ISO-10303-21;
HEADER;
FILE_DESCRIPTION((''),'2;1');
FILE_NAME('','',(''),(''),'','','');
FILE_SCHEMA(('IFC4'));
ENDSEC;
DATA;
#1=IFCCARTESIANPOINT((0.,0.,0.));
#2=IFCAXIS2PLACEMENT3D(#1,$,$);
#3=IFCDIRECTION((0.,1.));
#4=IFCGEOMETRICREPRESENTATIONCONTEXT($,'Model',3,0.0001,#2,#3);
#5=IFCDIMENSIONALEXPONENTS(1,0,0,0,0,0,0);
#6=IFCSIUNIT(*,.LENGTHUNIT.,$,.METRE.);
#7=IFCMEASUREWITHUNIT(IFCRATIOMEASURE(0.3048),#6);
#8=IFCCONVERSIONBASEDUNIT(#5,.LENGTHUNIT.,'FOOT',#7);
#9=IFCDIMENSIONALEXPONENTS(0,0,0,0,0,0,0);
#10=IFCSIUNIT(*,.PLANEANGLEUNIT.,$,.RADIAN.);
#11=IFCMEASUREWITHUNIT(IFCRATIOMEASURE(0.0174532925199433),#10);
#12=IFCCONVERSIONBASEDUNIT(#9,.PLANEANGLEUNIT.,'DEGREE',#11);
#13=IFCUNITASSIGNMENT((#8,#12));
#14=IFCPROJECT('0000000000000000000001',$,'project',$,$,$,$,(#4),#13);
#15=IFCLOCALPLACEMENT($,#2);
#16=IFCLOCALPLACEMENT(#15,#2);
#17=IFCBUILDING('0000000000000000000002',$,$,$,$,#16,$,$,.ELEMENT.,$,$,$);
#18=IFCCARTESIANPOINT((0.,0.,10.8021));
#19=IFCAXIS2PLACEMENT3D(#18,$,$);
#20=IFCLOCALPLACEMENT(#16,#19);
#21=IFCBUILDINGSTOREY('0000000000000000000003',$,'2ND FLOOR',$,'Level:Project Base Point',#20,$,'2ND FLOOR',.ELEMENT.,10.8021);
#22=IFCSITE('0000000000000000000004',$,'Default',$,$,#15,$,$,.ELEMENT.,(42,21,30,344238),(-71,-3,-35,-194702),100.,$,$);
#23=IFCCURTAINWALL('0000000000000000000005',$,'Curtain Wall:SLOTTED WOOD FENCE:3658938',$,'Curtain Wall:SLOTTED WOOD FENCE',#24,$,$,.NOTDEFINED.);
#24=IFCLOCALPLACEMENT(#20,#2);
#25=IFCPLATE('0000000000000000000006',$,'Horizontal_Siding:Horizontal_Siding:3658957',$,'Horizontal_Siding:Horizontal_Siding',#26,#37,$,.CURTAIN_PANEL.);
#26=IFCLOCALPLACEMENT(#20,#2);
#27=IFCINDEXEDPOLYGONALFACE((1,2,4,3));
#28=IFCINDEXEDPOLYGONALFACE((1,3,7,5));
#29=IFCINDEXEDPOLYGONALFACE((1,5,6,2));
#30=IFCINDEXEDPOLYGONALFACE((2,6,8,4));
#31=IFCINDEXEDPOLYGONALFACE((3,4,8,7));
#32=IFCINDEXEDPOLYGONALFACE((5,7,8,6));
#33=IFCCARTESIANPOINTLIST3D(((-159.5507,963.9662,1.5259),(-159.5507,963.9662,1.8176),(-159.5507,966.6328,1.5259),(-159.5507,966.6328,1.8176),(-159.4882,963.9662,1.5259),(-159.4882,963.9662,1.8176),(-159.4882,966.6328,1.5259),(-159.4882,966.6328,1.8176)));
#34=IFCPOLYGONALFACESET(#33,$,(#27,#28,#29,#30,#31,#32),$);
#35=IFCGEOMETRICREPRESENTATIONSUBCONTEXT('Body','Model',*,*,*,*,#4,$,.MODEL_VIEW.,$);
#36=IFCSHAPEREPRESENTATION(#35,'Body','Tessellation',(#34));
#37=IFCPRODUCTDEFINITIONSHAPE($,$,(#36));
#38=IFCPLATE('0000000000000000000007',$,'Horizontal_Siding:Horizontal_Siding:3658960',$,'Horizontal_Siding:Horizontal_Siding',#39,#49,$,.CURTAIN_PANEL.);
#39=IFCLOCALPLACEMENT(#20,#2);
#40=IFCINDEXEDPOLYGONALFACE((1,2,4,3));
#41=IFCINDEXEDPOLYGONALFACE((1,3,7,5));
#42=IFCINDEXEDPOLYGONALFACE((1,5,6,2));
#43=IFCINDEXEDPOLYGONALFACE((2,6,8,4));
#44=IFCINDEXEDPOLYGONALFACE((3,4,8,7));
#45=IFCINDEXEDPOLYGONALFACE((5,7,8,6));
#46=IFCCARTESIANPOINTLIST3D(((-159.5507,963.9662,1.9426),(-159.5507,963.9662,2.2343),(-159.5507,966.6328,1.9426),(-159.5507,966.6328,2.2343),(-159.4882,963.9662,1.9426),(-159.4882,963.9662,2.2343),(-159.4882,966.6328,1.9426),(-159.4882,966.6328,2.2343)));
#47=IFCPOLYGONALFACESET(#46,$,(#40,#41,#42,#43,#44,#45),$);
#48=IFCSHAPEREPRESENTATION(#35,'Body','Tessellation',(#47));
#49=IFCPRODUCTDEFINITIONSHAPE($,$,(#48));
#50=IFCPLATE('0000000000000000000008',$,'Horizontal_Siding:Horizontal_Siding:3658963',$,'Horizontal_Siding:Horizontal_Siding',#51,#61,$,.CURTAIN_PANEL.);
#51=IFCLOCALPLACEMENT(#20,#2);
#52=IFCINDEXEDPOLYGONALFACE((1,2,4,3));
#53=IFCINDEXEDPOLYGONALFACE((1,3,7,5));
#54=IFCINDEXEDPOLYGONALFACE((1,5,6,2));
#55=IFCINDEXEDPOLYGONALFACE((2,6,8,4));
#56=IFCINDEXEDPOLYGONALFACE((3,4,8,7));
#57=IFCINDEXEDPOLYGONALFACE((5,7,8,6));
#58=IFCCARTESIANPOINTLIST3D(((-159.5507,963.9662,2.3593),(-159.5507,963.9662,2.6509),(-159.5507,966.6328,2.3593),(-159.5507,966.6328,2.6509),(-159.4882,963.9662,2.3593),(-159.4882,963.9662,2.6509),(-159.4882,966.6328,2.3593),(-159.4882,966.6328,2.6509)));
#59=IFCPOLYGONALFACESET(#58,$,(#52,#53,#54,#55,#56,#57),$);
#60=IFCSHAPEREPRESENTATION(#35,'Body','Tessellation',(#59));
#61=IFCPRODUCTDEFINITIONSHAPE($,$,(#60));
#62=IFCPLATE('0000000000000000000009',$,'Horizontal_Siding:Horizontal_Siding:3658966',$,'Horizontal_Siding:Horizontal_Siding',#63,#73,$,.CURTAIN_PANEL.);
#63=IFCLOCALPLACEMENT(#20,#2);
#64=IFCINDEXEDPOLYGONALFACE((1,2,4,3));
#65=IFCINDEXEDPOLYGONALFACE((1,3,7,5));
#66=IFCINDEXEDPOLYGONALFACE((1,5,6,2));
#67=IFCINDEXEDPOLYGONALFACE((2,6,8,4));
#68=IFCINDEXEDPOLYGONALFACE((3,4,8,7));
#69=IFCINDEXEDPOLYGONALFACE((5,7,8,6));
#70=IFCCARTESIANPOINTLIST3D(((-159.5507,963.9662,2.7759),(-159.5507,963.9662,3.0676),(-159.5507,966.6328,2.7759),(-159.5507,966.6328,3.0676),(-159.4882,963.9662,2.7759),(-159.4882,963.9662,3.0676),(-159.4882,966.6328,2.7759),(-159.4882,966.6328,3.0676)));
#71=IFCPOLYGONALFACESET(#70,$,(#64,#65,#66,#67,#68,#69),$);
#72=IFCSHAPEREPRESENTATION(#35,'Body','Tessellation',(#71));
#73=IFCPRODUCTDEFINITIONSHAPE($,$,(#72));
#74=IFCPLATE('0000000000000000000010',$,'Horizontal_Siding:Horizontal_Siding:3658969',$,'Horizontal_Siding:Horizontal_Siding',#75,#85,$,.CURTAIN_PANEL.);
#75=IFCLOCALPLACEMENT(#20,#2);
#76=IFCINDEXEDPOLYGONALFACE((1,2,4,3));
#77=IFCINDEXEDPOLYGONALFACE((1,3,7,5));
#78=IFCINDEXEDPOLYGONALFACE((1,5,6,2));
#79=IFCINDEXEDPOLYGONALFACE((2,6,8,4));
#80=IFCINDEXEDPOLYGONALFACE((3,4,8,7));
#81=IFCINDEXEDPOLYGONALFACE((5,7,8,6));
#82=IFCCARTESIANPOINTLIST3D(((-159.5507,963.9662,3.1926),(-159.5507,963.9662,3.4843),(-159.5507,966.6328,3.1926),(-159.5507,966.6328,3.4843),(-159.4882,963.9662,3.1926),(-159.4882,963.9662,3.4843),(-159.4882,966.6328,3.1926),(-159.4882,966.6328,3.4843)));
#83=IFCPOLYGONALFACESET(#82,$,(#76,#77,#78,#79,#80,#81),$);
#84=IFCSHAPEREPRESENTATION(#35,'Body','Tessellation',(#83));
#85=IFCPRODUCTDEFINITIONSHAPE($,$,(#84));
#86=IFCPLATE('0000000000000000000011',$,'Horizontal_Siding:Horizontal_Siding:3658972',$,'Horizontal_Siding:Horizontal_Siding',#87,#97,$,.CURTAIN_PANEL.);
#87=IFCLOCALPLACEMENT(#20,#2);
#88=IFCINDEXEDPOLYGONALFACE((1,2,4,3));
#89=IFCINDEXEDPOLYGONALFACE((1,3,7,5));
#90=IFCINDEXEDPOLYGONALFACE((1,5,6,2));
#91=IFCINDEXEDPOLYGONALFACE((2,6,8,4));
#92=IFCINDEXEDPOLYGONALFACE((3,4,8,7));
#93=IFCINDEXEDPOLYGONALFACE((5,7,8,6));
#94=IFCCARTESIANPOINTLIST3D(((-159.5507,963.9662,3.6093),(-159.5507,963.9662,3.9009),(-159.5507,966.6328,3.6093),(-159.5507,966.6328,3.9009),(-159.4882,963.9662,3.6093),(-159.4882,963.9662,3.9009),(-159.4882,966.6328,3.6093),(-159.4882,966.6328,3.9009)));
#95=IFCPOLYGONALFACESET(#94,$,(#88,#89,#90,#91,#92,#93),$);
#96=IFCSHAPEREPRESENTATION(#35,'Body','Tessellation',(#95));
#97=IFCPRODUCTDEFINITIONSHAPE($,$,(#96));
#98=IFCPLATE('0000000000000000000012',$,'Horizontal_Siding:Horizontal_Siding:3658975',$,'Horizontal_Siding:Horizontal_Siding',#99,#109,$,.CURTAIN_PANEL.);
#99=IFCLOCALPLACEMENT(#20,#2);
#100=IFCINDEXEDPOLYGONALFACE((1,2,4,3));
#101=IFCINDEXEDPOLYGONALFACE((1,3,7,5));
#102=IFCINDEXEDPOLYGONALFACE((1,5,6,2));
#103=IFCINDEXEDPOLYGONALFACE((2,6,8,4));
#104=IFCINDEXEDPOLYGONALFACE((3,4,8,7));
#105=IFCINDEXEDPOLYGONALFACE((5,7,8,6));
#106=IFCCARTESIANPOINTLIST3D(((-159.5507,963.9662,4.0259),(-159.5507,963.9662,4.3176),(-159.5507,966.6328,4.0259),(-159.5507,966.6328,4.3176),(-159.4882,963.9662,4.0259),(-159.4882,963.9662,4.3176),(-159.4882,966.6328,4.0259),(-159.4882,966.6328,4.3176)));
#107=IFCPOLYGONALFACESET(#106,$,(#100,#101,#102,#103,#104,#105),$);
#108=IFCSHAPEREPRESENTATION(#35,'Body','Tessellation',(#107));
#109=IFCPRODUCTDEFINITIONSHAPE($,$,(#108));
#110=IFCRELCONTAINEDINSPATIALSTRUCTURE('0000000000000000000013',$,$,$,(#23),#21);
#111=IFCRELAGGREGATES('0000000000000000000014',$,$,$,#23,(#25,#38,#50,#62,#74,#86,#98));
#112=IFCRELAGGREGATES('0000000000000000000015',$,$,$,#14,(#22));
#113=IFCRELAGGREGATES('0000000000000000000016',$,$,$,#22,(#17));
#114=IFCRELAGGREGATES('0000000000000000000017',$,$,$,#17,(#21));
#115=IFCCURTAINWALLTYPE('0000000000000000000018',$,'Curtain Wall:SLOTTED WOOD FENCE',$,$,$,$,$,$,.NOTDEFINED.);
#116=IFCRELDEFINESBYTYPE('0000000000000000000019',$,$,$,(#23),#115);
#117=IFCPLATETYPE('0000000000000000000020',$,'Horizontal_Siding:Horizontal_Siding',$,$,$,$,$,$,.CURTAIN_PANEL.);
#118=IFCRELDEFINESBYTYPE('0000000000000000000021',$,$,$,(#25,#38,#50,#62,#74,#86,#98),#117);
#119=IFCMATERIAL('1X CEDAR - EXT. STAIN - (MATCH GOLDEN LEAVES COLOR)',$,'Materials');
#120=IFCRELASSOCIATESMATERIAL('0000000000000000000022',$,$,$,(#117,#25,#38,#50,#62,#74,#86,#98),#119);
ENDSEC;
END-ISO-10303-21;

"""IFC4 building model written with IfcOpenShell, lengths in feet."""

from ifc_helpers import new_model, entity, si_unit, converted_unit, direction, frame, origin, origin_2d_with_axis, place, context, subcontext, project, spatial, rectangle, extrude, source, transform, mapped, material, type_object, type_shapes, element, aggregate, save


model = new_model("IFC4")

# Units and contexts
model_context = context("Model", 3, precision=0.0001, world=origin(), true_north=direction((0.0, 1.0)))
body_context = subcontext(model_context, "Body", "Model", "MODEL_VIEW")
ifc_project = project(units=[converted_unit("LENGTHUNIT", "FOOT", entity("IfcRatioMeasure", 0.3048), si_unit("LENGTHUNIT", "METRE"), dimensions=[1, 0, 0, 0, 0, 0, 0]), converted_unit("PLANEANGLEUNIT", "DEGREE", entity("IfcRatioMeasure", 0.0174532925199433), si_unit("PLANEANGLEUNIT", "RADIAN"), dimensions=[0, 0, 0, 0, 0, 0, 0])], contexts=[model_context])

# Site, building, storey
site_placement = place(None, origin())
site = spatial("IfcSite", under=ifc_project, at=site_placement, Name="Default", CompositionType="ELEMENT", RefLatitude=(42, 21, 30, 344238), RefLongitude=(-71, -3, -35, -194702), RefElevation=100.0)
building_placement = place(site_placement, origin())
building = spatial("IfcBuilding", under=site, at=building_placement, CompositionType="ELEMENT")
storey_placement = place(building_placement, frame((0.0, 0.0, 10.8021)))
storey = spatial("IfcBuildingStorey", under=building, at=storey_placement, Name="2ND FLOOR", ObjectType="Level:Project Base Point", LongName="2ND FLOOR", CompositionType="ELEMENT", Elevation=10.8021)

# Curtain wall, plates
curtain_wall_type = type_object("IfcCurtainWallType", Name="Curtain Wall:SLOTTED WOOD FENCE", PredefinedType="NOTDEFINED")
curtain_wall_placement = place(storey_placement, frame((0.0, 0.0, -10.8021)))
curtain_wall = element("IfcCurtainWall", 1, at=curtain_wall_placement, inside=storey, type_object=curtain_wall_type, Name="Curtain Wall:SLOTTED WOOD FENCE:3658938", ObjectType="Curtain Wall:SLOTTED WOOD FENCE", PredefinedType="NOTDEFINED")
ifc_material_1 = material(Name="1X CEDAR - EXT. STAIN - (MATCH GOLDEN LEAVES COLOR)", Category="Materials")
plate_type = type_object("IfcPlateType", Name="Horizontal_Siding:Horizontal_Siding", PredefinedType="CURTAIN_PANEL", material=ifc_material_1)
shared_shape_1 = source(origin(), body_context, "Body", "SweptSolid", [
    extrude(rectangle(XDim=2.6667, YDim=0.0625, at=origin_2d_with_axis()), frame((1.3333, 0.0312, 0.0), z_axis=(0.0, 0.0, 1.0), x_axis=(-1.0, 0.0, 0.0)), (0.0, 0.0, 1.0), 0.2917),
])
type_shapes(plate_type, [shared_shape_1])
plate_1_placement = place(curtain_wall_placement, frame((-159.5507, 966.6328, 12.328), z_axis=(0.0, 0.0, 1.0), x_axis=(0.0, -1.0, 0.0)))
plate_1 = element("IfcPlate", 2, at=plate_1_placement, type_object=plate_type, material=ifc_material_1, Name="Horizontal_Siding:Horizontal_Siding:3658957", ObjectType="Horizontal_Siding:Horizontal_Siding", PredefinedType="CURTAIN_PANEL", context=body_context, shape_type="MappedRepresentation", body=[
    mapped(shared_shape_1, transform((0.0, 0.0, 0.0), scale=1.0)),
])
plate_2_placement = place(curtain_wall_placement, frame((-159.5507, 966.6328, 12.7447), z_axis=(0.0, 0.0, 1.0), x_axis=(0.0, -1.0, 0.0)))
plate_2 = element("IfcPlate", 3, at=plate_2_placement, type_object=plate_type, material=ifc_material_1, Name="Horizontal_Siding:Horizontal_Siding:3658960", ObjectType="Horizontal_Siding:Horizontal_Siding", PredefinedType="CURTAIN_PANEL", context=body_context, shape_type="MappedRepresentation", body=[
    mapped(shared_shape_1, transform((0.0, 0.0, 0.0), scale=1.0)),
])
plate_3_placement = place(curtain_wall_placement, frame((-159.5507, 966.6328, 13.1613), z_axis=(0.0, 0.0, 1.0), x_axis=(0.0, -1.0, 0.0)))
plate_3 = element("IfcPlate", 4, at=plate_3_placement, type_object=plate_type, material=ifc_material_1, Name="Horizontal_Siding:Horizontal_Siding:3658963", ObjectType="Horizontal_Siding:Horizontal_Siding", PredefinedType="CURTAIN_PANEL", context=body_context, shape_type="MappedRepresentation", body=[
    mapped(shared_shape_1, transform((0.0, 0.0, 0.0), scale=1.0)),
])
plate_4_placement = place(curtain_wall_placement, frame((-159.5507, 966.6328, 13.578), z_axis=(0.0, 0.0, 1.0), x_axis=(0.0, -1.0, 0.0)))
plate_4 = element("IfcPlate", 5, at=plate_4_placement, type_object=plate_type, material=ifc_material_1, Name="Horizontal_Siding:Horizontal_Siding:3658966", ObjectType="Horizontal_Siding:Horizontal_Siding", PredefinedType="CURTAIN_PANEL", context=body_context, shape_type="MappedRepresentation", body=[
    mapped(shared_shape_1, transform((0.0, 0.0, 0.0), scale=1.0)),
])
plate_5_placement = place(curtain_wall_placement, frame((-159.5507, 966.6328, 13.9947), z_axis=(0.0, 0.0, 1.0), x_axis=(0.0, -1.0, 0.0)))
plate_5 = element("IfcPlate", 6, at=plate_5_placement, type_object=plate_type, material=ifc_material_1, Name="Horizontal_Siding:Horizontal_Siding:3658969", ObjectType="Horizontal_Siding:Horizontal_Siding", PredefinedType="CURTAIN_PANEL", context=body_context, shape_type="MappedRepresentation", body=[
    mapped(shared_shape_1, transform((0.0, 0.0, 0.0), scale=1.0)),
])
plate_6_placement = place(curtain_wall_placement, frame((-159.5507, 966.6328, 14.4113), z_axis=(0.0, 0.0, 1.0), x_axis=(0.0, -1.0, 0.0)))
plate_6 = element("IfcPlate", 7, at=plate_6_placement, type_object=plate_type, material=ifc_material_1, Name="Horizontal_Siding:Horizontal_Siding:3658972", ObjectType="Horizontal_Siding:Horizontal_Siding", PredefinedType="CURTAIN_PANEL", context=body_context, shape_type="MappedRepresentation", body=[
    mapped(shared_shape_1, transform((0.0, 0.0, 0.0), scale=1.0)),
])
plate_7_placement = place(curtain_wall_placement, frame((-159.5507, 966.6328, 14.828), z_axis=(0.0, 0.0, 1.0), x_axis=(0.0, -1.0, 0.0)))
plate_7 = element("IfcPlate", 8, at=plate_7_placement, type_object=plate_type, material=ifc_material_1, Name="Horizontal_Siding:Horizontal_Siding:3658975", ObjectType="Horizontal_Siding:Horizontal_Siding", PredefinedType="CURTAIN_PANEL", context=body_context, shape_type="MappedRepresentation", body=[
    mapped(shared_shape_1, transform((0.0, 0.0, 0.0), scale=1.0)),
])
aggregate(curtain_wall, [plate_1, plate_2, plate_3, plate_4, plate_5, plate_6, plate_7])

save(model, "model.ifc")
